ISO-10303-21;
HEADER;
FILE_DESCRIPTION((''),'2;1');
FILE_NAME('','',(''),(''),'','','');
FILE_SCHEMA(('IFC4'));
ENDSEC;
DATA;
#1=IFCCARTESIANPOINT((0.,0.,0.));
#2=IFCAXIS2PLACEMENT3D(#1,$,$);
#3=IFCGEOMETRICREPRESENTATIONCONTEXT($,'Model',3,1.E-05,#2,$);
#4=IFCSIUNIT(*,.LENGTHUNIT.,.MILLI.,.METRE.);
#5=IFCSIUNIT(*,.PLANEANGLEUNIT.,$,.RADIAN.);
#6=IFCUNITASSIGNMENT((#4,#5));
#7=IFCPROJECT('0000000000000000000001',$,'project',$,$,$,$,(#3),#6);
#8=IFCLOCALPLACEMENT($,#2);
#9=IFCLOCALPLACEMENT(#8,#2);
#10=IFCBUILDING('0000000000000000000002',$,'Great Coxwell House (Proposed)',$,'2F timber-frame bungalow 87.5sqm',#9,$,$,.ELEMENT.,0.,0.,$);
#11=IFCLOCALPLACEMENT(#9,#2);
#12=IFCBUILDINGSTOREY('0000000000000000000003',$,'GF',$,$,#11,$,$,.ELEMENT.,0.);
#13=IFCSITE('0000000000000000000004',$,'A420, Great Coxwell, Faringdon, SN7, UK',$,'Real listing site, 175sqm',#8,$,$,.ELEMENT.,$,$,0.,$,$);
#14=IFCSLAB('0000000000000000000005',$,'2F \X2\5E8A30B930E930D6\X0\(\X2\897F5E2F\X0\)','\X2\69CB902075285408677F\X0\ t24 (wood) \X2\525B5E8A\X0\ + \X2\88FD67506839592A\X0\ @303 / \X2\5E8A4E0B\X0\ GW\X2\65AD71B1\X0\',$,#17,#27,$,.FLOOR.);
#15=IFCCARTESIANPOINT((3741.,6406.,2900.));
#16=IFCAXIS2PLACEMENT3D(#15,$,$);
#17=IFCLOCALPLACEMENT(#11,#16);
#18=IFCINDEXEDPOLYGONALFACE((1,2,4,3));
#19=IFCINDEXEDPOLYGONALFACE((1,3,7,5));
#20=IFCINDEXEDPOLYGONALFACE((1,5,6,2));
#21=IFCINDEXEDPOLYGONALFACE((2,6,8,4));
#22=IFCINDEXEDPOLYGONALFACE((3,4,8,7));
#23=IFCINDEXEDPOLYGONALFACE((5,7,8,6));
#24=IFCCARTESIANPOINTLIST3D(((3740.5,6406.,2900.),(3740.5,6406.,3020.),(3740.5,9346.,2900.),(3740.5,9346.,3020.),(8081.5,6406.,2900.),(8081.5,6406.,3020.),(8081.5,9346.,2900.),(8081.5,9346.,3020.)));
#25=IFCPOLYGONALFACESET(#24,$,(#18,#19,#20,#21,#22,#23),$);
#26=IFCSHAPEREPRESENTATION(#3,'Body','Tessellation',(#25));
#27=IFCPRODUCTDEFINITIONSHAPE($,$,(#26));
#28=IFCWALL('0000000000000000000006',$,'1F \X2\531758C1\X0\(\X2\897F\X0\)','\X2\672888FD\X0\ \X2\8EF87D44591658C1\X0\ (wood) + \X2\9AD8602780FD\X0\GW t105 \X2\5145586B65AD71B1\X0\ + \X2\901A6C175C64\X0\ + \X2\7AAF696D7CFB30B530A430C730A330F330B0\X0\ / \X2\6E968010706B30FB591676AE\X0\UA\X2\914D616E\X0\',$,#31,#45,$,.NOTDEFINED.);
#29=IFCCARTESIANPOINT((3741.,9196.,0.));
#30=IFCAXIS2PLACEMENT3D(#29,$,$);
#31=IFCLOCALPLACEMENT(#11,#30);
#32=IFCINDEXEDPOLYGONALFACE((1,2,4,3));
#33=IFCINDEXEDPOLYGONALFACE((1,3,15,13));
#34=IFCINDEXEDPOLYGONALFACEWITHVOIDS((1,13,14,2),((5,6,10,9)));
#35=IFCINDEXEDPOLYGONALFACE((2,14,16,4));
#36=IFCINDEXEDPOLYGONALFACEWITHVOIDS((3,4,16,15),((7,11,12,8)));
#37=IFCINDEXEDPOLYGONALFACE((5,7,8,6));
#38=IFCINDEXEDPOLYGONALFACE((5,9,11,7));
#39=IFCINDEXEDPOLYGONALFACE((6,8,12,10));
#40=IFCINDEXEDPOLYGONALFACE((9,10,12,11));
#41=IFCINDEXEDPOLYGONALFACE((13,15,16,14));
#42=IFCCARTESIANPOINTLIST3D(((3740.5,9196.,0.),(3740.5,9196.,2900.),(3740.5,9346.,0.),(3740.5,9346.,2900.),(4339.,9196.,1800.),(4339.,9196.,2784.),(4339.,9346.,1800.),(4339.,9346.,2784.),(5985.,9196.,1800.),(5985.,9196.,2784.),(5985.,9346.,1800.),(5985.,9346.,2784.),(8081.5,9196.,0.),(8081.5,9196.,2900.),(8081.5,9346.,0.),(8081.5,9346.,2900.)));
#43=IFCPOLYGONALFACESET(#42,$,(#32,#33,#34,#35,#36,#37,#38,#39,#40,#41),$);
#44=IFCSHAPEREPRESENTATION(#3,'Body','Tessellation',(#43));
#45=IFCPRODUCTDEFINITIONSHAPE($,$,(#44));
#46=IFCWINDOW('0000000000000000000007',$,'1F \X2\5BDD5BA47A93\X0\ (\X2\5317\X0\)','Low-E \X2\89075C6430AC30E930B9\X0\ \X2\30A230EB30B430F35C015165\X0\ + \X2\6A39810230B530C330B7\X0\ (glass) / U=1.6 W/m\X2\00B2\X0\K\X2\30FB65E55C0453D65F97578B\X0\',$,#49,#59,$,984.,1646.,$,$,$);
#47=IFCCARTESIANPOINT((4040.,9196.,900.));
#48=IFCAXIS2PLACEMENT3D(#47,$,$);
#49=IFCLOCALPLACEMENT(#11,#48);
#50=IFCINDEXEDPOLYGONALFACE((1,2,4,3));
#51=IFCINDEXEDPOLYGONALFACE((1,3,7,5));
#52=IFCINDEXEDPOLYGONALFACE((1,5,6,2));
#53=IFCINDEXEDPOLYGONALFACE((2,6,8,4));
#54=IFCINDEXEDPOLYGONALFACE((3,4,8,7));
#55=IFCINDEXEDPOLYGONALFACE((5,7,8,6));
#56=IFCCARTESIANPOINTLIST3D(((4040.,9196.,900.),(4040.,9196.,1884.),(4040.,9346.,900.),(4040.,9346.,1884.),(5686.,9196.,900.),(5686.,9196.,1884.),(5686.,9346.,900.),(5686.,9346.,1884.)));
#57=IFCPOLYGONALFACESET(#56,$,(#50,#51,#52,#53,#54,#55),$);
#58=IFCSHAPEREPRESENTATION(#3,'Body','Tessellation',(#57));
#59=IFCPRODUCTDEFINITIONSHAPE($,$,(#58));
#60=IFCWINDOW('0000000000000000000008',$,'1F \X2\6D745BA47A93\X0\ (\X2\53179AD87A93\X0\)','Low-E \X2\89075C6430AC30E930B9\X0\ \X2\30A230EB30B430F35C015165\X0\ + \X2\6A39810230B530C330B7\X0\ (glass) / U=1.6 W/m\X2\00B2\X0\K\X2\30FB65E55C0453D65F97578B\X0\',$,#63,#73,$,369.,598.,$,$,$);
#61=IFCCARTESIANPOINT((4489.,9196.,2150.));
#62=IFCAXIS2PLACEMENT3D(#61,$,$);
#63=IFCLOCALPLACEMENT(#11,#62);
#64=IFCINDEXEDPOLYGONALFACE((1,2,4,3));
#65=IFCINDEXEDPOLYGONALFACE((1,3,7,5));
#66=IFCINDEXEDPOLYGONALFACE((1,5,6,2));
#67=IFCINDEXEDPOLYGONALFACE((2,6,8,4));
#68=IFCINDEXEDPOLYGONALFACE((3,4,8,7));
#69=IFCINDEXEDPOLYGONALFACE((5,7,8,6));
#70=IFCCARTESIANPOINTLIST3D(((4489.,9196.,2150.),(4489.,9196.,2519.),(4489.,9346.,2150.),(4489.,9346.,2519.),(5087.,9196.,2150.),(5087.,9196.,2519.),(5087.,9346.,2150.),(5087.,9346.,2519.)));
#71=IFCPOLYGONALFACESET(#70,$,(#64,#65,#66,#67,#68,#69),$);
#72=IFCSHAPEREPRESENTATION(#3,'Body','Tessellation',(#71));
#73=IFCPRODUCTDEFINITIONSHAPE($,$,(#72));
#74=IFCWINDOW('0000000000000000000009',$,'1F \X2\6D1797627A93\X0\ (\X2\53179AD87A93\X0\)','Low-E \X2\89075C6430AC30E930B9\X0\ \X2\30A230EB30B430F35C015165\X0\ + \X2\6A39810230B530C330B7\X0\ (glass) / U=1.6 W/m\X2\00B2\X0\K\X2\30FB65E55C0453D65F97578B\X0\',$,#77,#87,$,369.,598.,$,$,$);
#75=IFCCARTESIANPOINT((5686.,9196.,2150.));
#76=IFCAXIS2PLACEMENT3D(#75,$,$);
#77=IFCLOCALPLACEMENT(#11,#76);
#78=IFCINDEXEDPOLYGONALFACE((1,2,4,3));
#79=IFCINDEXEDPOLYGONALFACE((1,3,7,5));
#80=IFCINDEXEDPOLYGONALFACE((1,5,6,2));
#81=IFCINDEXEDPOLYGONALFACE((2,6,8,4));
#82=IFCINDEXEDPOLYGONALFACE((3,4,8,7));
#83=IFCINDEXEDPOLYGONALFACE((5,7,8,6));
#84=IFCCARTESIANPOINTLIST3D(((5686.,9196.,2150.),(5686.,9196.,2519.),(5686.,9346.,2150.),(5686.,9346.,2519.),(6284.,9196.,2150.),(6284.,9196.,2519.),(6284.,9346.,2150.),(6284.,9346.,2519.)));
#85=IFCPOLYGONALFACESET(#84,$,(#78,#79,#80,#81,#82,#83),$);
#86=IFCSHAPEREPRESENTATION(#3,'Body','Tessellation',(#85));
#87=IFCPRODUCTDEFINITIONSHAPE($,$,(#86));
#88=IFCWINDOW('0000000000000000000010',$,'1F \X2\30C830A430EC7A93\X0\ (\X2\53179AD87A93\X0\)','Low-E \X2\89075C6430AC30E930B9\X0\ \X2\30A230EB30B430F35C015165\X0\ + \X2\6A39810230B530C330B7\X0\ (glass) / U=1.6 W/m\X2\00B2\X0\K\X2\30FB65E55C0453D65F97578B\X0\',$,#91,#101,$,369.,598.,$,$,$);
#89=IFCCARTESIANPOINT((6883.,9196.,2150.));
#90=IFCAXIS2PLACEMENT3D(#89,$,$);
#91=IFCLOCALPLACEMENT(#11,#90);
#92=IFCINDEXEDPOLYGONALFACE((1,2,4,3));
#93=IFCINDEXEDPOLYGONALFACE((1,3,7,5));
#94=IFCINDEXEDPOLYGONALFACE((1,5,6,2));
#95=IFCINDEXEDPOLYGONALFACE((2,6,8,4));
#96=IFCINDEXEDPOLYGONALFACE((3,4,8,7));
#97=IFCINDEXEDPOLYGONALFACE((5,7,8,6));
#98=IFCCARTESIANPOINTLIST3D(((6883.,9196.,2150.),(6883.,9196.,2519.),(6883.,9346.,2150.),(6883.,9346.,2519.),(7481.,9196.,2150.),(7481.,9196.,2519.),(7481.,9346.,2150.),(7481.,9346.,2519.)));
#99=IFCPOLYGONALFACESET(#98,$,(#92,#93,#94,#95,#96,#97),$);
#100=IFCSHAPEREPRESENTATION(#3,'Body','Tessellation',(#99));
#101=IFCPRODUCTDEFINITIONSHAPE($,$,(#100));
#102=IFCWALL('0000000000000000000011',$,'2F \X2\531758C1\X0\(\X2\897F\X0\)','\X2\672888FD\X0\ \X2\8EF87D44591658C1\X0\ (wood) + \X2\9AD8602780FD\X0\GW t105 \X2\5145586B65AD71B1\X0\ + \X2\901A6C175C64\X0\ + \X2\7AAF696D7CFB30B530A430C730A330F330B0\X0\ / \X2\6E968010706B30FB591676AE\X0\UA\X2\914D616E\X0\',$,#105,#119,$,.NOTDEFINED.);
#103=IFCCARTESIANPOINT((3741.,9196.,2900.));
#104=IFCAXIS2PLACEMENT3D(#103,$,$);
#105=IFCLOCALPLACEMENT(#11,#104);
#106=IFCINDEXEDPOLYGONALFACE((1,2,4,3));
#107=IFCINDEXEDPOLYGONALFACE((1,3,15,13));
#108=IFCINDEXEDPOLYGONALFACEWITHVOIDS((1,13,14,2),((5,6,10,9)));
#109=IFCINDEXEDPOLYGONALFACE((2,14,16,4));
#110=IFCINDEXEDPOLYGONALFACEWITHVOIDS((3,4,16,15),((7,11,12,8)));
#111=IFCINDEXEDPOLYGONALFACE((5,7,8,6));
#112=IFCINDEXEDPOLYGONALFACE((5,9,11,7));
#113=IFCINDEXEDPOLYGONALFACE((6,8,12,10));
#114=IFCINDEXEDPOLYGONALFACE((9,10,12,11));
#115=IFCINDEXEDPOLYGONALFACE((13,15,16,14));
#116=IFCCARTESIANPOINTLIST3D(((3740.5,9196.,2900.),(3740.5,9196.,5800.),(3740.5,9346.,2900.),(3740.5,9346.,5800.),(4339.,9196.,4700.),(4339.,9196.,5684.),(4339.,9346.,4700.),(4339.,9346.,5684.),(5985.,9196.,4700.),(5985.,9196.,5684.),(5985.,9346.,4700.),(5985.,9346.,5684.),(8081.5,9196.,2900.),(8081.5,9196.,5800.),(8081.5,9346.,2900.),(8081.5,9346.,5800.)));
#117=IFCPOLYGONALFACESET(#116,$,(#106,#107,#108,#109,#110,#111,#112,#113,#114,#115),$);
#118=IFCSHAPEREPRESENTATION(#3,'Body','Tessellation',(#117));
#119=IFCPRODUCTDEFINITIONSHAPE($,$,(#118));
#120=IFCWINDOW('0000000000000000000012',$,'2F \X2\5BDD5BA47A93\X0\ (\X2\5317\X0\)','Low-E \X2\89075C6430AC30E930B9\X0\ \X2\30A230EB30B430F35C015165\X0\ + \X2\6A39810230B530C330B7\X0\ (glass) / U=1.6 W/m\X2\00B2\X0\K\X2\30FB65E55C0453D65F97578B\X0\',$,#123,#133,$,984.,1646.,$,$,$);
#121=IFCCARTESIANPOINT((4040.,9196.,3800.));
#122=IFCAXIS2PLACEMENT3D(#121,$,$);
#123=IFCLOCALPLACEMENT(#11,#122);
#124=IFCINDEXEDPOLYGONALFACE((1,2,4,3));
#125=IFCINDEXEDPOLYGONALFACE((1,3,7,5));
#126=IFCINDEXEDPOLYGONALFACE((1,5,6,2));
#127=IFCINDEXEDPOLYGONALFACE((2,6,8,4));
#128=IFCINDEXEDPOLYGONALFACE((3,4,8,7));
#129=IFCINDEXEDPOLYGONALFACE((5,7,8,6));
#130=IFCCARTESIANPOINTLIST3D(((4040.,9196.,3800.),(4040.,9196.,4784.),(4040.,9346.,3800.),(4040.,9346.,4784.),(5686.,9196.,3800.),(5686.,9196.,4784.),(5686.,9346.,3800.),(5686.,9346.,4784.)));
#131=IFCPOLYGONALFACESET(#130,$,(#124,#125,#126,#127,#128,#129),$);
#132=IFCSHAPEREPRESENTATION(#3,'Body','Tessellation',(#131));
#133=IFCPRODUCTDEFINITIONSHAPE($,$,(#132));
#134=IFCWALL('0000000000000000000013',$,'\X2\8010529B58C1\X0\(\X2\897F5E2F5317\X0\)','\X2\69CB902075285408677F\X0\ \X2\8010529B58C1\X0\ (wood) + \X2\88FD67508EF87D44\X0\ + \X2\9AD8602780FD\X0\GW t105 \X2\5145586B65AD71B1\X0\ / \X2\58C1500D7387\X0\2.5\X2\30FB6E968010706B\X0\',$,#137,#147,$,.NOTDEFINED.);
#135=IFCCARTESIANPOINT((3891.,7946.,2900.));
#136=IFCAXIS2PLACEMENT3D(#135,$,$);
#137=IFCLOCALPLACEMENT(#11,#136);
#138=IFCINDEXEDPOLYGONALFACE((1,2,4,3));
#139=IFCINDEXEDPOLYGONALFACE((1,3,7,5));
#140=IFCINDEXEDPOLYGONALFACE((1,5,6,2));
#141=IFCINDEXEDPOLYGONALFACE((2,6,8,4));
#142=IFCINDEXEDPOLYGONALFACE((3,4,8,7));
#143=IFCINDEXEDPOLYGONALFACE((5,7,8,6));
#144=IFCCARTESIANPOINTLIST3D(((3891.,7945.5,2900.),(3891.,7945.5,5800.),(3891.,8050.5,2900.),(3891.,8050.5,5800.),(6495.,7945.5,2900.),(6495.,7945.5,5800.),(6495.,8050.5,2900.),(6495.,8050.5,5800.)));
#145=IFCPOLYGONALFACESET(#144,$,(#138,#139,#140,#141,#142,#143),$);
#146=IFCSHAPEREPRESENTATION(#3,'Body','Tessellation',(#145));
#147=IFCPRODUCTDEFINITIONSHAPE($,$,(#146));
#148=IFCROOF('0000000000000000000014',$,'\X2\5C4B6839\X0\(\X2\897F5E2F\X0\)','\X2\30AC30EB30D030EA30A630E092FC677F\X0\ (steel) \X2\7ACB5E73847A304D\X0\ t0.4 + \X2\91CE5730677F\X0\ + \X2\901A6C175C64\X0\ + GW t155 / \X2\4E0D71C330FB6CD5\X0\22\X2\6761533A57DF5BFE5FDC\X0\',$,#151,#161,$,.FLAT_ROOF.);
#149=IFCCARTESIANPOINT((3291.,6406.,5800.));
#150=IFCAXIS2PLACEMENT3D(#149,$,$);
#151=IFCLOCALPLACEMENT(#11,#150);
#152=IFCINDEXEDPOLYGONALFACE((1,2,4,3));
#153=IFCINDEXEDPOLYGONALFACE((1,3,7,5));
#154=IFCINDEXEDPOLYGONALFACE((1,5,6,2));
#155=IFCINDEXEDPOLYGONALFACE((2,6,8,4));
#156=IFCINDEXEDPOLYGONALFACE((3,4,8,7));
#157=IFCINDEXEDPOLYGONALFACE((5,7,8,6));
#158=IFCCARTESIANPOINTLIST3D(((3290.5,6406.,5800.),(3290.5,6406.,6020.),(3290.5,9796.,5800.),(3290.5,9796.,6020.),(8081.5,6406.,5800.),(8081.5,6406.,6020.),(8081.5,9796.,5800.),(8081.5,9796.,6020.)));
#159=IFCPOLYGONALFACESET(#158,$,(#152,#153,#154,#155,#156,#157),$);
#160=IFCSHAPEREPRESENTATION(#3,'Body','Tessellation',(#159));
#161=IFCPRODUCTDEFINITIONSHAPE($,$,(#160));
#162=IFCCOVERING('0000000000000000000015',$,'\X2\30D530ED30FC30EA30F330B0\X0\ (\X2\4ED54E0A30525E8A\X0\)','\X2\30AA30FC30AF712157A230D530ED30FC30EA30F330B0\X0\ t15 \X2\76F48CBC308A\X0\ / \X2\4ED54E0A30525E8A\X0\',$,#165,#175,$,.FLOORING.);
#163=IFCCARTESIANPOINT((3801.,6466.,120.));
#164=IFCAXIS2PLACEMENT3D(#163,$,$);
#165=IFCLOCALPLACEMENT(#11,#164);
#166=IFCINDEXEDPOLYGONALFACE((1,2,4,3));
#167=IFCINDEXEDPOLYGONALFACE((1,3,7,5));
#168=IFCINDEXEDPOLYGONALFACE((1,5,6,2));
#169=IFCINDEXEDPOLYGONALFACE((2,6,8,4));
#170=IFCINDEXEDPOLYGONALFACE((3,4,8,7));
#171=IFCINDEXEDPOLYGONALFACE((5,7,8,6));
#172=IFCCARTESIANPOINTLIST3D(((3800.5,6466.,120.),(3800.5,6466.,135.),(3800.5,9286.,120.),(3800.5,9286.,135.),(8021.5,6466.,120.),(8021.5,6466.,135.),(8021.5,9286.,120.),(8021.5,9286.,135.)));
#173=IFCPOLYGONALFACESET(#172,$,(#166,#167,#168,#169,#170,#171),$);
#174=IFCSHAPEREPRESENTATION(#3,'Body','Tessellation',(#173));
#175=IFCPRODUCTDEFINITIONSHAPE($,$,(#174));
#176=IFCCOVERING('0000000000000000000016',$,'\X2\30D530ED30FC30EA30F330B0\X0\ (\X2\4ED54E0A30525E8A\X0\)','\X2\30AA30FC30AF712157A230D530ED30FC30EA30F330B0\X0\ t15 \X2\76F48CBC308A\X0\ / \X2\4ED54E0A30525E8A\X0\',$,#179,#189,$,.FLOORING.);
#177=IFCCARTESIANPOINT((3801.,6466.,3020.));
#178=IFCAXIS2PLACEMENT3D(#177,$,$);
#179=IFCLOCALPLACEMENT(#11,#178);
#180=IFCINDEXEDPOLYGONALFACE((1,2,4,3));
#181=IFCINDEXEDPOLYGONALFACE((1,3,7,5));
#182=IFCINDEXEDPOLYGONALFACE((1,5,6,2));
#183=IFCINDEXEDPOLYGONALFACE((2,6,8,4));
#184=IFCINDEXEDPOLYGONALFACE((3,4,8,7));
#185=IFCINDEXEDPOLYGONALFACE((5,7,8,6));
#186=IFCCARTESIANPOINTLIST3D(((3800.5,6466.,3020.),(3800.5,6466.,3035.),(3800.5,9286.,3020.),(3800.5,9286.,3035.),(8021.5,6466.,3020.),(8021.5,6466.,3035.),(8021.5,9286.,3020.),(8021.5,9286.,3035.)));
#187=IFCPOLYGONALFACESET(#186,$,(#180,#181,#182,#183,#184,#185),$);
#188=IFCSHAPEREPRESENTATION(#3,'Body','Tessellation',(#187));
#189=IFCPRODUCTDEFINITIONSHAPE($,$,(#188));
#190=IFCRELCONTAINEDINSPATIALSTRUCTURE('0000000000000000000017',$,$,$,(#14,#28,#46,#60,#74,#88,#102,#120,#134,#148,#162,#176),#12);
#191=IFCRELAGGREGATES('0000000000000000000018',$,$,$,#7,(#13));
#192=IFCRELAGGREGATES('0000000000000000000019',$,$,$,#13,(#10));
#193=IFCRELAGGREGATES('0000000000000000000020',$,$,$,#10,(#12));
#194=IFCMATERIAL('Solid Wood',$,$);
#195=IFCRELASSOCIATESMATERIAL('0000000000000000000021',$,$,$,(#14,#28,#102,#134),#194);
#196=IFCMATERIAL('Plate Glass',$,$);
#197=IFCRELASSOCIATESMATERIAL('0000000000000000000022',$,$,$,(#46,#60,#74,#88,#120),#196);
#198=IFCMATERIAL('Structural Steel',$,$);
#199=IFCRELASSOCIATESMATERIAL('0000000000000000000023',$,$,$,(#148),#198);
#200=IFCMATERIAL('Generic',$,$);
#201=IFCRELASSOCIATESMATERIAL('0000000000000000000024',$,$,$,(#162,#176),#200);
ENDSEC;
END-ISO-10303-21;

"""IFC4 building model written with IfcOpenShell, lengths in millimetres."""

from ifc_helpers import new_model, si_unit, frame, frame_2d, origin, place, context, project, spatial, rectangle, extrude, material, element, fill, save


model = new_model("IFC4")

# Units and contexts
model_context = context("Model", 3, precision=1e-05, world=origin())
ifc_project = project(units=[si_unit("LENGTHUNIT", "METRE", prefix="MILLI"), si_unit("PLANEANGLEUNIT", "RADIAN")], contexts=[model_context])

# Site, building, storey
site_placement = place(None, origin())
site = spatial("IfcSite", under=ifc_project, at=site_placement, Name="A420, Great Coxwell, Faringdon, SN7, UK", ObjectType="Real listing site, 175sqm", CompositionType="ELEMENT", RefElevation=0.0)
building_placement = place(site_placement, origin())
building = spatial("IfcBuilding", under=site, at=building_placement, Name="Great Coxwell House (Proposed)", ObjectType="2F timber-frame bungalow 87.5sqm", CompositionType="ELEMENT", ElevationOfRefHeight=0.0, ElevationOfTerrain=0.0)
storey_placement = place(building_placement, origin())
storey = spatial("IfcBuildingStorey", under=building, at=storey_placement, Name="GF", CompositionType="ELEMENT", Elevation=0.0)

# Slab
ifc_material_1 = material(Name="Solid Wood")
slab_1_placement = place(storey_placement, frame((3741.0, 6406.0, 2900.0)))
element("IfcSlab", 1, at=slab_1_placement, inside=storey, material=ifc_material_1, Name="2F 床スラブ(西帯)", Description="構造用合板 t24 (wood) 剛床 + 製材根太 @303 / 床下 GW断熱", PredefinedType="FLOOR", context=model_context, shape_type="SweptSolid", body=[
    extrude(rectangle(XDim=4341.0, YDim=2940.0, at=frame_2d((2170.0, 1470.0))), frame((3741.0, 6406.0, 2900.0)), (0.0, 0.0, 1.0), 120.0),
])

# Wall, openings, windows
wall_1_placement = place(storey_placement, frame((3741.0, 9196.0, 0.0)))
wall_1 = element("IfcWall", 2, at=wall_1_placement, inside=storey, material=ifc_material_1, Name="1F 北壁(西)", Description="木製 軸組外壁 (wood) + 高性能GW t105 充填断熱 + 通気層 + 窯業系サイディング / 準耐火・外皮UA配慮", PredefinedType="NOTDEFINED", context=model_context, shape_type="SweptSolid", body=[
    extrude(rectangle(XDim=4341.0, YDim=150.0, at=frame_2d((2170.0, 75.0))), frame((3741.0, 9196.0, 0.0)), (0.0, 0.0, 1.0), 2900.0),
])
opening_1_placement = place(storey_placement, frame((4040.0, 9196.0, 900.0)))
opening_1 = element("IfcOpeningElement", 3, at=opening_1_placement, cuts=wall_1, PredefinedType="NOTDEFINED", context=model_context, shape_type="SweptSolid", body=[
    extrude(rectangle(XDim=1646.0, YDim=150.0, at=frame_2d((823.0, 75.0))), frame((4040.0, 9196.0, 900.0)), (0.0, 0.0, 1.0), 984.0),
])
opening_2_placement = place(storey_placement, frame((4489.0, 9196.0, 2150.0)))
opening_2 = element("IfcOpeningElement", 4, at=opening_2_placement, cuts=wall_1, PredefinedType="NOTDEFINED", context=model_context, shape_type="SweptSolid", body=[
    extrude(rectangle(XDim=598.0, YDim=150.0, at=frame_2d((299.0, 75.0))), frame((4489.0, 9196.0, 2150.0)), (0.0, 0.0, 1.0), 369.0),
])
opening_3_placement = place(storey_placement, frame((5686.0, 9196.0, 2150.0)))
opening_3 = element("IfcOpeningElement", 5, at=opening_3_placement, cuts=wall_1, PredefinedType="NOTDEFINED", context=model_context, shape_type="SweptSolid", body=[
    extrude(rectangle(XDim=598.0, YDim=150.0, at=frame_2d((299.0, 75.0))), frame((5686.0, 9196.0, 2150.0)), (0.0, 0.0, 1.0), 369.0),
])
opening_4_placement = place(storey_placement, frame((6883.0, 9196.0, 2150.0)))
opening_4 = element("IfcOpeningElement", 6, at=opening_4_placement, cuts=wall_1, PredefinedType="NOTDEFINED", context=model_context, shape_type="SweptSolid", body=[
    extrude(rectangle(XDim=598.0, YDim=150.0, at=frame_2d((299.0, 75.0))), frame((6883.0, 9196.0, 2150.0)), (0.0, 0.0, 1.0), 369.0),
])
ifc_material_2 = material(Name="Plate Glass")
window_1_placement = place(storey_placement, frame((4040.0, 9196.0, 900.0)))
window_1 = element("IfcWindow", 7, at=window_1_placement, inside=storey, material=ifc_material_2, Name="1F 寝室窓 (北)", Description="Low-E 複層ガラス アルゴン封入 + 樹脂サッシ (glass) / U=1.6 W/m²K・日射取得型", OverallHeight=984.0, OverallWidth=1646.0, context=model_context, shape_type="SweptSolid", body=[
    extrude(rectangle(XDim=1646.0, YDim=150.0, at=frame_2d((823.0, 75.0))), frame((4040.0, 9196.0, 900.0)), (0.0, 0.0, 1.0), 984.0),
])
fill(opening_1, window_1)
window_2_placement = place(storey_placement, frame((4489.0, 9196.0, 2150.0)))
window_2 = element("IfcWindow", 8, at=window_2_placement, inside=storey, material=ifc_material_2, Name="1F 浴室窓 (北高窓)", Description="Low-E 複層ガラス アルゴン封入 + 樹脂サッシ (glass) / U=1.6 W/m²K・日射取得型", OverallHeight=369.0, OverallWidth=598.0, context=model_context, shape_type="SweptSolid", body=[
    extrude(rectangle(XDim=598.0, YDim=150.0, at=frame_2d((299.0, 75.0))), frame((4489.0, 9196.0, 2150.0)), (0.0, 0.0, 1.0), 369.0),
])
fill(opening_2, window_2)
window_3_placement = place(storey_placement, frame((5686.0, 9196.0, 2150.0)))
window_3 = element("IfcWindow", 9, at=window_3_placement, inside=storey, material=ifc_material_2, Name="1F 洗面窓 (北高窓)", Description="Low-E 複層ガラス アルゴン封入 + 樹脂サッシ (glass) / U=1.6 W/m²K・日射取得型", OverallHeight=369.0, OverallWidth=598.0, context=model_context, shape_type="SweptSolid", body=[
    extrude(rectangle(XDim=598.0, YDim=150.0, at=frame_2d((299.0, 75.0))), frame((5686.0, 9196.0, 2150.0)), (0.0, 0.0, 1.0), 369.0),
])
fill(opening_3, window_3)
window_4_placement = place(storey_placement, frame((6883.0, 9196.0, 2150.0)))
window_4 = element("IfcWindow", 10, at=window_4_placement, inside=storey, material=ifc_material_2, Name="1F トイレ窓 (北高窓)", Description="Low-E 複層ガラス アルゴン封入 + 樹脂サッシ (glass) / U=1.6 W/m²K・日射取得型", OverallHeight=369.0, OverallWidth=598.0, context=model_context, shape_type="SweptSolid", body=[
    extrude(rectangle(XDim=598.0, YDim=150.0, at=frame_2d((299.0, 75.0))), frame((6883.0, 9196.0, 2150.0)), (0.0, 0.0, 1.0), 369.0),
])
fill(opening_4, window_4)

# Wall, opening, window
wall_2_placement = place(storey_placement, frame((3741.0, 9196.0, 2900.0)))
wall_2 = element("IfcWall", 11, at=wall_2_placement, inside=storey, material=ifc_material_1, Name="2F 北壁(西)", Description="木製 軸組外壁 (wood) + 高性能GW t105 充填断熱 + 通気層 + 窯業系サイディング / 準耐火・外皮UA配慮", PredefinedType="NOTDEFINED", context=model_context, shape_type="SweptSolid", body=[
    extrude(rectangle(XDim=4341.0, YDim=150.0, at=frame_2d((2170.0, 75.0))), frame((3741.0, 9196.0, 2900.0)), (0.0, 0.0, 1.0), 2900.0),
])
opening_5_placement = place(storey_placement, frame((4040.0, 9196.0, 3800.0)))
opening_5 = element("IfcOpeningElement", 12, at=opening_5_placement, cuts=wall_2, PredefinedType="NOTDEFINED", context=model_context, shape_type="SweptSolid", body=[
    extrude(rectangle(XDim=1646.0, YDim=150.0, at=frame_2d((823.0, 75.0))), frame((4040.0, 9196.0, 3800.0)), (0.0, 0.0, 1.0), 984.0),
])
window_5_placement = place(storey_placement, frame((4040.0, 9196.0, 3800.0)))
window_5 = element("IfcWindow", 13, at=window_5_placement, inside=storey, material=ifc_material_2, Name="2F 寝室窓 (北)", Description="Low-E 複層ガラス アルゴン封入 + 樹脂サッシ (glass) / U=1.6 W/m²K・日射取得型", OverallHeight=984.0, OverallWidth=1646.0, context=model_context, shape_type="SweptSolid", body=[
    extrude(rectangle(XDim=1646.0, YDim=150.0, at=frame_2d((823.0, 75.0))), frame((4040.0, 9196.0, 3800.0)), (0.0, 0.0, 1.0), 984.0),
])
fill(opening_5, window_5)

# Wall
wall_3_placement = place(storey_placement, frame((3891.0, 7946.0, 2900.0)))
element("IfcWall", 14, at=wall_3_placement, inside=storey, material=ifc_material_1, Name="耐力壁(西帯北)", Description="構造用合板 耐力壁 (wood) + 製材軸組 + 高性能GW t105 充填断熱 / 壁倍率2.5・準耐火", PredefinedType="NOTDEFINED", context=model_context, shape_type="SweptSolid", body=[
    extrude(rectangle(XDim=2604.0, YDim=105.0, at=frame_2d((1302.0, 52.0))), frame((3891.0, 7946.0, 2900.0)), (0.0, 0.0, 1.0), 2900.0),
])

# Roof
ifc_material_3 = material(Name="Structural Steel")
for number, where, name in (
    (15, (3291.0, 6406.0, 5800.0), "屋根(西帯)"),
):
    element("IfcRoof", number, at=place(storey_placement, frame(where)), inside=storey, material=ifc_material_3, Name=name, Description="ガルバリウム鋼板 (steel) 立平葺き t0.4 + 野地板 + 通気層 + GW t155 / 不燃・法22条区域対応", PredefinedType="FLAT_ROOF", context=model_context, shape_type="SweptSolid", body=[
        extrude(rectangle(XDim=4791.0, YDim=3390.0, at=frame_2d((2395.0, 1695.0))), frame((3291.0, 6406.0, 5800.0)), (0.0, 0.0, 1.0), 220.0),
    ])

# Coverings
ifc_material_4 = material(Name="Generic")
covering_1_placement = place(storey_placement, frame((3801.0, 6466.0, 120.0)))
element("IfcCovering", 16, at=covering_1_placement, inside=storey, material=ifc_material_4, Name="フローリング (仕上げ床)", Description="オーク無垢フローリング t15 直貼り / 仕上げ床", PredefinedType="FLOORING", context=model_context, shape_type="SweptSolid", body=[
    extrude(rectangle(XDim=4221.0, YDim=2820.0, at=frame_2d((2110.0, 1410.0))), frame((3801.0, 6466.0, 120.0)), (0.0, 0.0, 1.0), 15.0),
])
covering_2_placement = place(storey_placement, frame((3801.0, 6466.0, 3020.0)))
element("IfcCovering", 17, at=covering_2_placement, inside=storey, material=ifc_material_4, Name="フローリング (仕上げ床)", Description="オーク無垢フローリング t15 直貼り / 仕上げ床", PredefinedType="FLOORING", context=model_context, shape_type="SweptSolid", body=[
    extrude(rectangle(XDim=4221.0, YDim=2820.0, at=frame_2d((2110.0, 1410.0))), frame((3801.0, 6466.0, 3020.0)), (0.0, 0.0, 1.0), 15.0),
])

save(model, "model.ifc")
